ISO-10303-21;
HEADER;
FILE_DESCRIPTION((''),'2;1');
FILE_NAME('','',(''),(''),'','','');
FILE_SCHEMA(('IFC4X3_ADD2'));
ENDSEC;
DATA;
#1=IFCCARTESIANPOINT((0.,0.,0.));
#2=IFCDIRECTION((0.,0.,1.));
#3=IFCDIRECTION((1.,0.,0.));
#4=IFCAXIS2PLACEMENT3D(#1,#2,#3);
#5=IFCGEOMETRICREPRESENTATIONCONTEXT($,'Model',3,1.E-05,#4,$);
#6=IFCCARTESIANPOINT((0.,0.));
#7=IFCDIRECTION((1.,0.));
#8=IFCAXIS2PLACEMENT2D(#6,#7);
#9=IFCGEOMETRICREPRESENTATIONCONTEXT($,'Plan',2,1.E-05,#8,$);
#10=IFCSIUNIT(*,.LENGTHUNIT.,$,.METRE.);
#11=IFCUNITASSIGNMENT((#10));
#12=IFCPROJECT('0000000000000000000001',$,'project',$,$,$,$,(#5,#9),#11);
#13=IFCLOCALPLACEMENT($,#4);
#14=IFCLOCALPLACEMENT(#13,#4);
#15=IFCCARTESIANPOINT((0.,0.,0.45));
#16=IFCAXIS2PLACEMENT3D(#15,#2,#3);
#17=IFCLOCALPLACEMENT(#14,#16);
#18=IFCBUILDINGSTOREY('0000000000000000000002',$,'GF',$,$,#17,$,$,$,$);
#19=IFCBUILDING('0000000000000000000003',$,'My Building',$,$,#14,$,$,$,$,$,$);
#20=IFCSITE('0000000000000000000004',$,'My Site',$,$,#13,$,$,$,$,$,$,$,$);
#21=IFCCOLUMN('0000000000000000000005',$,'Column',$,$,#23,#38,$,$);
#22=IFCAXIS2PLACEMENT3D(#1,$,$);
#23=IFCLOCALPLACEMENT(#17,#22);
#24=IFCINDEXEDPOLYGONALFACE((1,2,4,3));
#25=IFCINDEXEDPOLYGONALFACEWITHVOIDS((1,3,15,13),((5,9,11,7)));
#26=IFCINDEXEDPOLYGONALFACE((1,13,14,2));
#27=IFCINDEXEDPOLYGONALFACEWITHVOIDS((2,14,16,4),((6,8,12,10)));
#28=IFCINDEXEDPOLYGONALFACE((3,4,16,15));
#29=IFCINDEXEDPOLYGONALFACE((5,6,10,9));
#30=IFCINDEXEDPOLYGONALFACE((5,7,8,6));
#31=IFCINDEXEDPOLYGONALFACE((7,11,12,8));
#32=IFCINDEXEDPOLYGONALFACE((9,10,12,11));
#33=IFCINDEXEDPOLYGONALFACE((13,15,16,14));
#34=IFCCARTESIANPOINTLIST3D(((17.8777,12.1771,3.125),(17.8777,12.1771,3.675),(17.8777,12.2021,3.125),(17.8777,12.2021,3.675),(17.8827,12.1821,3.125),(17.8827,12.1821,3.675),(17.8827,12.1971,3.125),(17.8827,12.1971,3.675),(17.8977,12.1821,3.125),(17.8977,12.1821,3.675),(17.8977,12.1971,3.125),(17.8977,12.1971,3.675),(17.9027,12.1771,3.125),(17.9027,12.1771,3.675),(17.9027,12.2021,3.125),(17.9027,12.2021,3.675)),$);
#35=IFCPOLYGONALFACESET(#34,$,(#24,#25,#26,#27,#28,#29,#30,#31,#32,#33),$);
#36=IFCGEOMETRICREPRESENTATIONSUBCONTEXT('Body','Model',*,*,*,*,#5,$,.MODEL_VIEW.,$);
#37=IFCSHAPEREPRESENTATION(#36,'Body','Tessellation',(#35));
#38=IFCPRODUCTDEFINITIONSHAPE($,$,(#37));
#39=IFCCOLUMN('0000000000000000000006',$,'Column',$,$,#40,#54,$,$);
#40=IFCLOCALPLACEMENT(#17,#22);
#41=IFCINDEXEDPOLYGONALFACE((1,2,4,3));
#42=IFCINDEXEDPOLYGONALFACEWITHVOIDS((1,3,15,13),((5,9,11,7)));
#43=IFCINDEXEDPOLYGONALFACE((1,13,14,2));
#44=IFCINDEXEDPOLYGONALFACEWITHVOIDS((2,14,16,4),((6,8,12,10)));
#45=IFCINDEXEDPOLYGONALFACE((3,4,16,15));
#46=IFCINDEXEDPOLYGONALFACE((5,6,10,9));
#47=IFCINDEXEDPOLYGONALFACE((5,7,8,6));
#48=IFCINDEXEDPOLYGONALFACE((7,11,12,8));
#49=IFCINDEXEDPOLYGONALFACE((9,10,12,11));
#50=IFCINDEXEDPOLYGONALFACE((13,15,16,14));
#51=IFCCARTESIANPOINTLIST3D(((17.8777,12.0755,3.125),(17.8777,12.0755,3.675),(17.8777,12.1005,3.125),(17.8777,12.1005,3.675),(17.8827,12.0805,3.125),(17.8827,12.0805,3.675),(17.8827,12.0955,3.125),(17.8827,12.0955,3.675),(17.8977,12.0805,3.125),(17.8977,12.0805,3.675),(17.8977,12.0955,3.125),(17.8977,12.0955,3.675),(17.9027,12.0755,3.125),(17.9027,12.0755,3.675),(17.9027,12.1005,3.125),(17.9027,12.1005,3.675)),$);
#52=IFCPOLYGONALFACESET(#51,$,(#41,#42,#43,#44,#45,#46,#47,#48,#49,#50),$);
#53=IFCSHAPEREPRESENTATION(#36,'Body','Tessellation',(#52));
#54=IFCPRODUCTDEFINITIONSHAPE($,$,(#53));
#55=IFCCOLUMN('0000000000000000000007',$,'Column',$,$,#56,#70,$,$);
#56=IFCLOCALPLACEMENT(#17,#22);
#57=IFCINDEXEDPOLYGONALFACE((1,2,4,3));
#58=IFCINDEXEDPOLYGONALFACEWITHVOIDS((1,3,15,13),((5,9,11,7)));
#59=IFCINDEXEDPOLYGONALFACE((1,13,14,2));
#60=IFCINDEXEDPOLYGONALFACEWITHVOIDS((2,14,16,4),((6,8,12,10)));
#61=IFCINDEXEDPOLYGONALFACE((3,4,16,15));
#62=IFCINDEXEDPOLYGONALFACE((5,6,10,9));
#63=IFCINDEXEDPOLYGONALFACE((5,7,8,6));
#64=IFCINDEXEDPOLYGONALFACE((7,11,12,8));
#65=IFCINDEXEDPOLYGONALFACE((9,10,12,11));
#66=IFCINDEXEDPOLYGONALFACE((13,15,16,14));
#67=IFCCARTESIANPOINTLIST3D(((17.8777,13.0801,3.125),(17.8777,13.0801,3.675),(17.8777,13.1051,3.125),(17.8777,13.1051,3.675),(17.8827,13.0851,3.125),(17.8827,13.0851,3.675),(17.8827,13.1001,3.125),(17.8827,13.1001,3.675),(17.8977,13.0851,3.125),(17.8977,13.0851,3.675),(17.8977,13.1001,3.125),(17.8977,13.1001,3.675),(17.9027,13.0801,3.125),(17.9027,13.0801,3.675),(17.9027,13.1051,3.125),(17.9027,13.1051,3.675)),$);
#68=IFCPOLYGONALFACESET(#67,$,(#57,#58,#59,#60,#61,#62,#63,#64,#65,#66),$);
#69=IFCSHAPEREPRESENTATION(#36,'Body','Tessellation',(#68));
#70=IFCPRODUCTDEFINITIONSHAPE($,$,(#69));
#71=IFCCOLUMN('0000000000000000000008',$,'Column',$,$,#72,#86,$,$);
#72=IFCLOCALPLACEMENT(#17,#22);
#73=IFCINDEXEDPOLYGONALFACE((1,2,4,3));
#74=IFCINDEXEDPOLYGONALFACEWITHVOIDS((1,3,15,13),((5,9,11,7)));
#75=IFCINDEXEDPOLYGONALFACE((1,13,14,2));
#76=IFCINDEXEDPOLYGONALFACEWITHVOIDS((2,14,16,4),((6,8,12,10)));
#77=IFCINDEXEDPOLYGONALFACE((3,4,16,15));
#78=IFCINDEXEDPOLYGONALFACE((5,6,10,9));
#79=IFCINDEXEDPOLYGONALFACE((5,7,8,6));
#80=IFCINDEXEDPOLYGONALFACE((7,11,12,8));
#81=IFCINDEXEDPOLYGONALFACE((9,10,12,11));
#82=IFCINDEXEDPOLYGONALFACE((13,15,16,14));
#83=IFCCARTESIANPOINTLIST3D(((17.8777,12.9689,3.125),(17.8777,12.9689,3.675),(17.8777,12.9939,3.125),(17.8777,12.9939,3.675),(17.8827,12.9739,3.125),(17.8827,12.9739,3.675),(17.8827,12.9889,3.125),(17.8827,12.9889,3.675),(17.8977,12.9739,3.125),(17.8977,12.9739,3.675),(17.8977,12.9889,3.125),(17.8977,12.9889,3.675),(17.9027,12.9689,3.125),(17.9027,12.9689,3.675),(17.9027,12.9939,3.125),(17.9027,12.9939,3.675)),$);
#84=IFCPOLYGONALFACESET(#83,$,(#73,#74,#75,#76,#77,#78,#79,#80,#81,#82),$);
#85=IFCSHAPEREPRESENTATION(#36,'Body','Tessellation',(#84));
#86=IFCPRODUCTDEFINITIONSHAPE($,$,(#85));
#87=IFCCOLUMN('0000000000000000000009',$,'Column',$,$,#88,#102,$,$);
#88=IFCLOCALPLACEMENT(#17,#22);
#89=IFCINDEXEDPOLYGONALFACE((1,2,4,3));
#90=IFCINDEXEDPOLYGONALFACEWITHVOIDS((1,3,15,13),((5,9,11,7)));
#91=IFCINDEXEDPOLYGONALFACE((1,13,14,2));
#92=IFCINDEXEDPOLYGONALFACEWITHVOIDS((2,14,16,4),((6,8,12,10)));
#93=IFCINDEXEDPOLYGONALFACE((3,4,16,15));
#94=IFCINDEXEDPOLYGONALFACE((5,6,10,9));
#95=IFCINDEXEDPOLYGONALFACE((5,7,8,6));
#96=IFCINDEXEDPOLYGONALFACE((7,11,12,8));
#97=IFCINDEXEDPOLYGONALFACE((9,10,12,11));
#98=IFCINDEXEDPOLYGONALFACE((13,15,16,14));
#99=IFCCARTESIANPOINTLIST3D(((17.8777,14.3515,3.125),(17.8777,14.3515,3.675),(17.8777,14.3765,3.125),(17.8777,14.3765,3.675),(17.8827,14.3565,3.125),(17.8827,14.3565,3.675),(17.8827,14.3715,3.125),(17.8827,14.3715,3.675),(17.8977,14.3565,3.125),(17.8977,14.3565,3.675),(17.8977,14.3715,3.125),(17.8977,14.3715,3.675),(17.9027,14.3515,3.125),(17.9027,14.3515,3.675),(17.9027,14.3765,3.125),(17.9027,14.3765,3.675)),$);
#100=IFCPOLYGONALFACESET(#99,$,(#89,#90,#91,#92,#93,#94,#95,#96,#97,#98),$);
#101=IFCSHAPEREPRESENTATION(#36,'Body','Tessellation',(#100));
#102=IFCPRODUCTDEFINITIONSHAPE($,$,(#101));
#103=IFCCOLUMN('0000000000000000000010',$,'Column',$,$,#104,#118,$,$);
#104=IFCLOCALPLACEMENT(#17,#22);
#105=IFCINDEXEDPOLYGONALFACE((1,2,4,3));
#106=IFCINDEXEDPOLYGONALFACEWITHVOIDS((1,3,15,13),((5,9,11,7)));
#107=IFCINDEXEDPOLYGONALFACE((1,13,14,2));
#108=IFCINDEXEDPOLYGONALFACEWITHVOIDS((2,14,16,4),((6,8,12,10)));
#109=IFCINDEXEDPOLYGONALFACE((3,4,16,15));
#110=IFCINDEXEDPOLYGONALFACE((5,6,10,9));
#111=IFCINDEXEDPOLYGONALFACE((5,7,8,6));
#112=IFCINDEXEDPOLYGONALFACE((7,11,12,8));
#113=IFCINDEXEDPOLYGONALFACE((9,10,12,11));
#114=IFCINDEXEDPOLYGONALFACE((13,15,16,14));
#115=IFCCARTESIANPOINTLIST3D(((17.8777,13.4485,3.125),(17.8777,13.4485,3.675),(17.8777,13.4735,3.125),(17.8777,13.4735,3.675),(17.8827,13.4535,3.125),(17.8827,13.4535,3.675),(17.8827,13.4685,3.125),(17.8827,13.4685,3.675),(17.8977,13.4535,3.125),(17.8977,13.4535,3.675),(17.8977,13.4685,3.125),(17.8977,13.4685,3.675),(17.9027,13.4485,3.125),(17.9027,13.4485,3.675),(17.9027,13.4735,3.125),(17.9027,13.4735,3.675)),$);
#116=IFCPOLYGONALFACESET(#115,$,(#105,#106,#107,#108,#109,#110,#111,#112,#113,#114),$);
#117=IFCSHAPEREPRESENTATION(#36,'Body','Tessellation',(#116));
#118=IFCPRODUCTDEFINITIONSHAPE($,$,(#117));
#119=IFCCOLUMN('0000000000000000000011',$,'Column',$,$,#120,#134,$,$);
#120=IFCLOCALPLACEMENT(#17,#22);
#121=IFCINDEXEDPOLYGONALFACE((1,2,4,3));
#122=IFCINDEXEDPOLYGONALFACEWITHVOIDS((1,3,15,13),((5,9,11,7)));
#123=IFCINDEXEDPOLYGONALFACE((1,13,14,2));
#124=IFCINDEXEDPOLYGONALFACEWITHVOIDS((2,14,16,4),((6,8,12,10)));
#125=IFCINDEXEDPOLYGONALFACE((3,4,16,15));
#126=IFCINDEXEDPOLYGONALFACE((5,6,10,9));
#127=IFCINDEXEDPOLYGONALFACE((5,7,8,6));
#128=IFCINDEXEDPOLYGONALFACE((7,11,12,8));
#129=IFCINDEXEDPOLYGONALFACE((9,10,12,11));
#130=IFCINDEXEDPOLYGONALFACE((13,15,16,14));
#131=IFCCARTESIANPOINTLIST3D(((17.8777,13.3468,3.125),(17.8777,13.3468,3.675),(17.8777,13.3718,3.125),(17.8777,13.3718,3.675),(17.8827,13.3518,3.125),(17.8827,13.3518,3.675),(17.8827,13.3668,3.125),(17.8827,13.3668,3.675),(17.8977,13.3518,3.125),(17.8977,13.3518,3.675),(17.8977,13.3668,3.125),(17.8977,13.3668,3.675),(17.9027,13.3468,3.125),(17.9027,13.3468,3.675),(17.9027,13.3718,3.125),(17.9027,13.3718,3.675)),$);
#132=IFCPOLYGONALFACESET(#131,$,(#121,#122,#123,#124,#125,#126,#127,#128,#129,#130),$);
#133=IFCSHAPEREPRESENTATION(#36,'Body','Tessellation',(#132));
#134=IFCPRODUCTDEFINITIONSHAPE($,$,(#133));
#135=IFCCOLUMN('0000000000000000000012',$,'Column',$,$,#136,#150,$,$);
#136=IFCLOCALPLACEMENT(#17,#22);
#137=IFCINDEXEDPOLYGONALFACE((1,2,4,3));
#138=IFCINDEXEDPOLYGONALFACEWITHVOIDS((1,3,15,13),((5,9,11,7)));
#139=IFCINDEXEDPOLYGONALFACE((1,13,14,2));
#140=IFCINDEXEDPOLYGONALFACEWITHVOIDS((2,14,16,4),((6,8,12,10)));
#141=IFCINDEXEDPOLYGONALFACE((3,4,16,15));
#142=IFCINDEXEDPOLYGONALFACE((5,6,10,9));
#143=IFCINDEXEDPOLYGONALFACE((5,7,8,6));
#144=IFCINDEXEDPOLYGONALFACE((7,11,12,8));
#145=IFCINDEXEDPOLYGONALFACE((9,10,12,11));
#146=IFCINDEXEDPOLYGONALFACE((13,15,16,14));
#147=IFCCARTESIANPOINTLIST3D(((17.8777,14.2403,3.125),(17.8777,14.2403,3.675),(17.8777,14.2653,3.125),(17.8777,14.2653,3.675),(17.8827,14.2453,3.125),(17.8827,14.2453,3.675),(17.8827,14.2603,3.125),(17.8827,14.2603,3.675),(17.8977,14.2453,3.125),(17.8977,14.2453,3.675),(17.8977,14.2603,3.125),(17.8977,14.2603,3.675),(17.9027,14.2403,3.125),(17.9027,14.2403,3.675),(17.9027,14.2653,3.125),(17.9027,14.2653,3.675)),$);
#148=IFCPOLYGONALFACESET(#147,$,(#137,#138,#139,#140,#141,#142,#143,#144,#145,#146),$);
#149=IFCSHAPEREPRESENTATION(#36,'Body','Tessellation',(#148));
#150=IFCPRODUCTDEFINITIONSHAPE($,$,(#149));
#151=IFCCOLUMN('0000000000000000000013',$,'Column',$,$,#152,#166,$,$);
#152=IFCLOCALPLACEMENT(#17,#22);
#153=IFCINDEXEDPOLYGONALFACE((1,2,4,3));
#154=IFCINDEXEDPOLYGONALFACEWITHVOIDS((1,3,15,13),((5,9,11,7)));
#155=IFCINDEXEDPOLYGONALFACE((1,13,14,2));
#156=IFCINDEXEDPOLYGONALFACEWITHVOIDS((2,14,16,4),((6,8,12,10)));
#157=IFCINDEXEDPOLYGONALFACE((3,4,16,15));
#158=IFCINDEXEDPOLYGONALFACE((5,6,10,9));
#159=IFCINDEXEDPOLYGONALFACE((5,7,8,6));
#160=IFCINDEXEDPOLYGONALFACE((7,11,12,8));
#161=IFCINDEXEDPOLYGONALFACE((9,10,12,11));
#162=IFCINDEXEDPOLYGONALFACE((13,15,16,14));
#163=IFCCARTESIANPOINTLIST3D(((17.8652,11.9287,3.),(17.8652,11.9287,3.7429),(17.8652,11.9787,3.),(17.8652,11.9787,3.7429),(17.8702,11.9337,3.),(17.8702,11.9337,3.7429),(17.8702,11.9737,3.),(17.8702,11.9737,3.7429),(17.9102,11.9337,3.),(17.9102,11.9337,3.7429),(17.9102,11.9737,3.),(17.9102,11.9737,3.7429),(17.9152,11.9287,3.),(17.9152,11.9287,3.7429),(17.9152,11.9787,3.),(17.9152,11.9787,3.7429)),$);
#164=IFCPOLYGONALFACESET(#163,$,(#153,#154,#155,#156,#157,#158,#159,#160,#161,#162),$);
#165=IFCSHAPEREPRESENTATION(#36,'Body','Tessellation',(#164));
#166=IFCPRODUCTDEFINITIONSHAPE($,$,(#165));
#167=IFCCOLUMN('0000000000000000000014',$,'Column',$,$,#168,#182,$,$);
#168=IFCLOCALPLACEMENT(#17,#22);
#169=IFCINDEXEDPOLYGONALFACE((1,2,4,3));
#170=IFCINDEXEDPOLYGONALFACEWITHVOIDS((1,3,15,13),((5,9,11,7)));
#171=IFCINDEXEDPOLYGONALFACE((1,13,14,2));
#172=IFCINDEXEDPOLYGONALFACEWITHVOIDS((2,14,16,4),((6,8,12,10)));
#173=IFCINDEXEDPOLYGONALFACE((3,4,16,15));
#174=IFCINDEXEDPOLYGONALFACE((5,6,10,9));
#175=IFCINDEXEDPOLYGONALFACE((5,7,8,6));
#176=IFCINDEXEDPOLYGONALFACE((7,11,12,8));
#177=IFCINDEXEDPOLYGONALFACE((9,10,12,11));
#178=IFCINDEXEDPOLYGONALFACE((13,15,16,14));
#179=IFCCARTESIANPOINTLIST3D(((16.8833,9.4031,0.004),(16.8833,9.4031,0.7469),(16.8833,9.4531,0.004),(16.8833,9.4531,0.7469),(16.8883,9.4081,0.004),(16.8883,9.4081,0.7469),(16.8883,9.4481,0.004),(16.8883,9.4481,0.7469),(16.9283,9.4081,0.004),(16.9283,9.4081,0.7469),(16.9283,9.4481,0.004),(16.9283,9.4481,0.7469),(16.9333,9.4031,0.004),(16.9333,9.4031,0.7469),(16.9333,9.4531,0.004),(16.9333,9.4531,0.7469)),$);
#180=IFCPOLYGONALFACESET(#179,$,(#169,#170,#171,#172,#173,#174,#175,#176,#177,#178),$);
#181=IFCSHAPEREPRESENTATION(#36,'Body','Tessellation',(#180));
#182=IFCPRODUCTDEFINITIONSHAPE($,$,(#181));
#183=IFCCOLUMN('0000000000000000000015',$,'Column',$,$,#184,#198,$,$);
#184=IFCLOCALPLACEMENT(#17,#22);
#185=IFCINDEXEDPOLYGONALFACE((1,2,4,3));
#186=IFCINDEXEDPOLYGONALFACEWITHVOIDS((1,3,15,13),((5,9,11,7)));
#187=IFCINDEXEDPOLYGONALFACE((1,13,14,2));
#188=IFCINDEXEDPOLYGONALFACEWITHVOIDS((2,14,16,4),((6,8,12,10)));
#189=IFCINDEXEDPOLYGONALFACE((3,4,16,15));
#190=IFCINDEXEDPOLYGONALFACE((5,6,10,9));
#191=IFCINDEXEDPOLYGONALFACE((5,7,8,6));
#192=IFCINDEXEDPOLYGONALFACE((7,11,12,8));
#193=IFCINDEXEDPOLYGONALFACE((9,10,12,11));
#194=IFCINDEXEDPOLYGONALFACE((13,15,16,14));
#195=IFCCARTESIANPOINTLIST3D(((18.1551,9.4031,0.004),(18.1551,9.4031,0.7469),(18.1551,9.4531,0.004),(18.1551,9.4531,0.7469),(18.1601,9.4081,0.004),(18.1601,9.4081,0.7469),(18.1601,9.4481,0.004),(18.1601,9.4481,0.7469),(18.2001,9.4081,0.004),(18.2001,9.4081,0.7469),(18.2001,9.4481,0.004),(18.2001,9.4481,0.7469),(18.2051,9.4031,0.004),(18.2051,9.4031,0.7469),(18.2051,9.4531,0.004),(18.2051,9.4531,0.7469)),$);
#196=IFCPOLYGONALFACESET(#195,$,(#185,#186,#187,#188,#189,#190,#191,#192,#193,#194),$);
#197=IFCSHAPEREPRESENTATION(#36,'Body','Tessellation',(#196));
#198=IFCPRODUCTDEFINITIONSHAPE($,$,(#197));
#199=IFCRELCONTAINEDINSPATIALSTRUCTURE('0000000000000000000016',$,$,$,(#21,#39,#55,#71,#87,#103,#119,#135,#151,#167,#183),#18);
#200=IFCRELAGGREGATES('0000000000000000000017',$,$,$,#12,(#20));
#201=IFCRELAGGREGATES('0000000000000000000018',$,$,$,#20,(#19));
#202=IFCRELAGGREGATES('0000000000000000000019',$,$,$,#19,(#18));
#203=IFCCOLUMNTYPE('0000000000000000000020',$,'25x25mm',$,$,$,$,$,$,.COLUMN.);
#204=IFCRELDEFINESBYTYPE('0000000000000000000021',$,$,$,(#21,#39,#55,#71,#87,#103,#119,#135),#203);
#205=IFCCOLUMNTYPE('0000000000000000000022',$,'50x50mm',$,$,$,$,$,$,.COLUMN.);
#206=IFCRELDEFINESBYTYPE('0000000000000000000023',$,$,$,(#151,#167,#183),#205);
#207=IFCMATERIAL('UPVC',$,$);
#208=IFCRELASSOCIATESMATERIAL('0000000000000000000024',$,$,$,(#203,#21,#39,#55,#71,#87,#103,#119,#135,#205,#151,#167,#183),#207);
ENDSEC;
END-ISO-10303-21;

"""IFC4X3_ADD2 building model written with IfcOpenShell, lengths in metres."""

from ifc_helpers import new_model, si_unit, frame, origin_with_axes, origin_2d_with_axis, place, context, subcontext, project, spatial, hollow_rectangle, extrude, material, material_profile, profile_set, profile_usage, type_object, element, save


model = new_model("IFC4X3_ADD2")

# Units and contexts
model_context = context("Model", 3, precision=1e-05, world=origin_with_axes())
plan_context = context("Plan", 2, precision=1e-05, world=origin_2d_with_axis())
body_context_1 = subcontext(model_context, "Body", "Model", "MODEL_VIEW")
ifc_project = project(units=[si_unit("LENGTHUNIT", "METRE")], contexts=[model_context, plan_context])

# Site, building, storey
site_placement = place(None, origin_with_axes())
site = spatial("IfcSite", under=ifc_project, at=site_placement, Name="My Site")
building_placement = place(site_placement, origin_with_axes())
building = spatial("IfcBuilding", under=site, at=building_placement, Name="My Building")
storey_placement = place(building_placement, frame((0.0, 0.0, 0.45), z_axis=(0.0, 0.0, 1.0), x_axis=(1.0, 0.0, 0.0)))
storey = spatial("IfcBuildingStorey", under=building, at=storey_placement, Name="GF")

# Columns
ifc_material_1 = material(Name="UPVC")
ifc_material_profile_1 = material_profile(ifc_material_1, hollow_rectangle(XDim=0.025, YDim=0.025, WallThickness=0.005))
ifc_profile_set_1 = profile_set([ifc_material_profile_1])
column_type_1 = type_object("IfcColumnType", Name="25x25mm", PredefinedType="COLUMN", material=ifc_profile_set_1)
ifc_profile_usage_1 = profile_usage(ifc_profile_set_1)
column_1_placement = place(storey_placement, frame((17.8902, 12.1896, 3.125), z_axis=(0.0, 0.0, 1.0), x_axis=(0.0, -1.0, 0.0)))
element("IfcColumn", 1, at=column_1_placement, inside=storey, type_object=column_type_1, material=ifc_profile_usage_1, Name="Column", context=body_context_1, shape_type="SweptSolid", body=[
    extrude(hollow_rectangle(XDim=0.025, YDim=0.025, WallThickness=0.005), origin_with_axes(), (0.0, 0.0, 1.0), 0.55),
])
ifc_profile_usage_2 = profile_usage(ifc_profile_set_1)
column_2_placement = place(storey_placement, frame((17.8902, 12.088, 3.125), z_axis=(0.0, 0.0, 1.0), x_axis=(0.0, -1.0, 0.0)))
element("IfcColumn", 2, at=column_2_placement, inside=storey, type_object=column_type_1, material=ifc_profile_usage_2, Name="Column", context=body_context_1, shape_type="SweptSolid", body=[
    extrude(hollow_rectangle(XDim=0.025, YDim=0.025, WallThickness=0.005), origin_with_axes(), (0.0, 0.0, 1.0), 0.55),
])
ifc_profile_usage_3 = profile_usage(ifc_profile_set_1)
column_3_placement = place(storey_placement, frame((17.8902, 13.0926, 3.125), z_axis=(0.0, 0.0, 1.0), x_axis=(0.0, -1.0, 0.0)))
element("IfcColumn", 3, at=column_3_placement, inside=storey, type_object=column_type_1, material=ifc_profile_usage_3, Name="Column", context=body_context_1, shape_type="SweptSolid", body=[
    extrude(hollow_rectangle(XDim=0.025, YDim=0.025, WallThickness=0.005), origin_with_axes(), (0.0, 0.0, 1.0), 0.55),
])
ifc_profile_usage_4 = profile_usage(ifc_profile_set_1)
column_4_placement = place(storey_placement, frame((17.8902, 12.9814, 3.125), z_axis=(0.0, 0.0, 1.0), x_axis=(0.0, -1.0, 0.0)))
element("IfcColumn", 4, at=column_4_placement, inside=storey, type_object=column_type_1, material=ifc_profile_usage_4, Name="Column", context=body_context_1, shape_type="SweptSolid", body=[
    extrude(hollow_rectangle(XDim=0.025, YDim=0.025, WallThickness=0.005), origin_with_axes(), (0.0, 0.0, 1.0), 0.55),
])
ifc_profile_usage_5 = profile_usage(ifc_profile_set_1)
column_5_placement = place(storey_placement, frame((17.8902, 14.364, 3.125), z_axis=(0.0, 0.0, 1.0), x_axis=(0.0, -1.0, 0.0)))
element("IfcColumn", 5, at=column_5_placement, inside=storey, type_object=column_type_1, material=ifc_profile_usage_5, Name="Column", context=body_context_1, shape_type="SweptSolid", body=[
    extrude(hollow_rectangle(XDim=0.025, YDim=0.025, WallThickness=0.005), origin_with_axes(), (0.0, 0.0, 1.0), 0.55),
])
ifc_profile_usage_6 = profile_usage(ifc_profile_set_1)
column_6_placement = place(storey_placement, frame((17.8902, 13.461, 3.125), z_axis=(0.0, 0.0, 1.0), x_axis=(0.0, -1.0, 0.0)))
element("IfcColumn", 6, at=column_6_placement, inside=storey, type_object=column_type_1, material=ifc_profile_usage_6, Name="Column", context=body_context_1, shape_type="SweptSolid", body=[
    extrude(hollow_rectangle(XDim=0.025, YDim=0.025, WallThickness=0.005), origin_with_axes(), (0.0, 0.0, 1.0), 0.55),
])
ifc_profile_usage_7 = profile_usage(ifc_profile_set_1)
column_7_placement = place(storey_placement, frame((17.8902, 13.3593, 3.125), z_axis=(0.0, 0.0, 1.0), x_axis=(0.0, -1.0, 0.0)))
element("IfcColumn", 7, at=column_7_placement, inside=storey, type_object=column_type_1, material=ifc_profile_usage_7, Name="Column", context=body_context_1, shape_type="SweptSolid", body=[
    extrude(hollow_rectangle(XDim=0.025, YDim=0.025, WallThickness=0.005), origin_with_axes(), (0.0, 0.0, 1.0), 0.55),
])
ifc_profile_usage_8 = profile_usage(ifc_profile_set_1)
column_8_placement = place(storey_placement, frame((17.8902, 14.2528, 3.125), z_axis=(0.0, 0.0, 1.0), x_axis=(0.0, -1.0, 0.0)))
element("IfcColumn", 8, at=column_8_placement, inside=storey, type_object=column_type_1, material=ifc_profile_usage_8, Name="Column", context=body_context_1, shape_type="SweptSolid", body=[
    extrude(hollow_rectangle(XDim=0.025, YDim=0.025, WallThickness=0.005), origin_with_axes(), (0.0, 0.0, 1.0), 0.55),
])
ifc_material_profile_2 = material_profile(ifc_material_1, hollow_rectangle(XDim=0.05, YDim=0.05, WallThickness=0.005))
ifc_profile_set_2 = profile_set([ifc_material_profile_2])
ifc_profile_usage_9 = profile_usage(ifc_profile_set_2)
column_type_2 = type_object("IfcColumnType", Name="50x50mm", PredefinedType="COLUMN", material=ifc_profile_set_2)
column_9_placement = place(storey_placement, frame((17.8902, 11.9537, 3.0), z_axis=(0.0, 0.0, 1.0), x_axis=(0.0, -1.0, 0.0)))
element("IfcColumn", 9, at=column_9_placement, inside=storey, type_object=column_type_2, material=ifc_profile_usage_9, Name="Column", context=body_context_1, shape_type="SweptSolid", body=[
    extrude(hollow_rectangle(XDim=0.05, YDim=0.05, WallThickness=0.005), origin_with_axes(), (0.0, 0.0, 1.0), 0.7429),
])
ifc_profile_usage_10 = profile_usage(ifc_profile_set_2)
column_10_placement = place(storey_placement, frame((16.9083, 9.4281, 0.004), z_axis=(0.0, 0.0, 1.0), x_axis=(1.0, 0.0, 0.0)))
element("IfcColumn", 10, at=column_10_placement, inside=storey, type_object=column_type_2, material=ifc_profile_usage_10, Name="Column", context=body_context_1, shape_type="SweptSolid", body=[
    extrude(hollow_rectangle(XDim=0.05, YDim=0.05, WallThickness=0.005), origin_with_axes(), (0.0, 0.0, 1.0), 0.7429),
])
ifc_profile_usage_11 = profile_usage(ifc_profile_set_2)
column_11_placement = place(storey_placement, frame((18.1801, 9.4281, 0.004), z_axis=(0.0, 0.0, 1.0), x_axis=(1.0, 0.0, 0.0)))
element("IfcColumn", 11, at=column_11_placement, inside=storey, type_object=column_type_2, material=ifc_profile_usage_11, Name="Column", context=body_context_1, shape_type="SweptSolid", body=[
    extrude(hollow_rectangle(XDim=0.05, YDim=0.05, WallThickness=0.005), origin_with_axes(), (0.0, 0.0, 1.0), 0.7429),
])

save(model, "model.ifc")
